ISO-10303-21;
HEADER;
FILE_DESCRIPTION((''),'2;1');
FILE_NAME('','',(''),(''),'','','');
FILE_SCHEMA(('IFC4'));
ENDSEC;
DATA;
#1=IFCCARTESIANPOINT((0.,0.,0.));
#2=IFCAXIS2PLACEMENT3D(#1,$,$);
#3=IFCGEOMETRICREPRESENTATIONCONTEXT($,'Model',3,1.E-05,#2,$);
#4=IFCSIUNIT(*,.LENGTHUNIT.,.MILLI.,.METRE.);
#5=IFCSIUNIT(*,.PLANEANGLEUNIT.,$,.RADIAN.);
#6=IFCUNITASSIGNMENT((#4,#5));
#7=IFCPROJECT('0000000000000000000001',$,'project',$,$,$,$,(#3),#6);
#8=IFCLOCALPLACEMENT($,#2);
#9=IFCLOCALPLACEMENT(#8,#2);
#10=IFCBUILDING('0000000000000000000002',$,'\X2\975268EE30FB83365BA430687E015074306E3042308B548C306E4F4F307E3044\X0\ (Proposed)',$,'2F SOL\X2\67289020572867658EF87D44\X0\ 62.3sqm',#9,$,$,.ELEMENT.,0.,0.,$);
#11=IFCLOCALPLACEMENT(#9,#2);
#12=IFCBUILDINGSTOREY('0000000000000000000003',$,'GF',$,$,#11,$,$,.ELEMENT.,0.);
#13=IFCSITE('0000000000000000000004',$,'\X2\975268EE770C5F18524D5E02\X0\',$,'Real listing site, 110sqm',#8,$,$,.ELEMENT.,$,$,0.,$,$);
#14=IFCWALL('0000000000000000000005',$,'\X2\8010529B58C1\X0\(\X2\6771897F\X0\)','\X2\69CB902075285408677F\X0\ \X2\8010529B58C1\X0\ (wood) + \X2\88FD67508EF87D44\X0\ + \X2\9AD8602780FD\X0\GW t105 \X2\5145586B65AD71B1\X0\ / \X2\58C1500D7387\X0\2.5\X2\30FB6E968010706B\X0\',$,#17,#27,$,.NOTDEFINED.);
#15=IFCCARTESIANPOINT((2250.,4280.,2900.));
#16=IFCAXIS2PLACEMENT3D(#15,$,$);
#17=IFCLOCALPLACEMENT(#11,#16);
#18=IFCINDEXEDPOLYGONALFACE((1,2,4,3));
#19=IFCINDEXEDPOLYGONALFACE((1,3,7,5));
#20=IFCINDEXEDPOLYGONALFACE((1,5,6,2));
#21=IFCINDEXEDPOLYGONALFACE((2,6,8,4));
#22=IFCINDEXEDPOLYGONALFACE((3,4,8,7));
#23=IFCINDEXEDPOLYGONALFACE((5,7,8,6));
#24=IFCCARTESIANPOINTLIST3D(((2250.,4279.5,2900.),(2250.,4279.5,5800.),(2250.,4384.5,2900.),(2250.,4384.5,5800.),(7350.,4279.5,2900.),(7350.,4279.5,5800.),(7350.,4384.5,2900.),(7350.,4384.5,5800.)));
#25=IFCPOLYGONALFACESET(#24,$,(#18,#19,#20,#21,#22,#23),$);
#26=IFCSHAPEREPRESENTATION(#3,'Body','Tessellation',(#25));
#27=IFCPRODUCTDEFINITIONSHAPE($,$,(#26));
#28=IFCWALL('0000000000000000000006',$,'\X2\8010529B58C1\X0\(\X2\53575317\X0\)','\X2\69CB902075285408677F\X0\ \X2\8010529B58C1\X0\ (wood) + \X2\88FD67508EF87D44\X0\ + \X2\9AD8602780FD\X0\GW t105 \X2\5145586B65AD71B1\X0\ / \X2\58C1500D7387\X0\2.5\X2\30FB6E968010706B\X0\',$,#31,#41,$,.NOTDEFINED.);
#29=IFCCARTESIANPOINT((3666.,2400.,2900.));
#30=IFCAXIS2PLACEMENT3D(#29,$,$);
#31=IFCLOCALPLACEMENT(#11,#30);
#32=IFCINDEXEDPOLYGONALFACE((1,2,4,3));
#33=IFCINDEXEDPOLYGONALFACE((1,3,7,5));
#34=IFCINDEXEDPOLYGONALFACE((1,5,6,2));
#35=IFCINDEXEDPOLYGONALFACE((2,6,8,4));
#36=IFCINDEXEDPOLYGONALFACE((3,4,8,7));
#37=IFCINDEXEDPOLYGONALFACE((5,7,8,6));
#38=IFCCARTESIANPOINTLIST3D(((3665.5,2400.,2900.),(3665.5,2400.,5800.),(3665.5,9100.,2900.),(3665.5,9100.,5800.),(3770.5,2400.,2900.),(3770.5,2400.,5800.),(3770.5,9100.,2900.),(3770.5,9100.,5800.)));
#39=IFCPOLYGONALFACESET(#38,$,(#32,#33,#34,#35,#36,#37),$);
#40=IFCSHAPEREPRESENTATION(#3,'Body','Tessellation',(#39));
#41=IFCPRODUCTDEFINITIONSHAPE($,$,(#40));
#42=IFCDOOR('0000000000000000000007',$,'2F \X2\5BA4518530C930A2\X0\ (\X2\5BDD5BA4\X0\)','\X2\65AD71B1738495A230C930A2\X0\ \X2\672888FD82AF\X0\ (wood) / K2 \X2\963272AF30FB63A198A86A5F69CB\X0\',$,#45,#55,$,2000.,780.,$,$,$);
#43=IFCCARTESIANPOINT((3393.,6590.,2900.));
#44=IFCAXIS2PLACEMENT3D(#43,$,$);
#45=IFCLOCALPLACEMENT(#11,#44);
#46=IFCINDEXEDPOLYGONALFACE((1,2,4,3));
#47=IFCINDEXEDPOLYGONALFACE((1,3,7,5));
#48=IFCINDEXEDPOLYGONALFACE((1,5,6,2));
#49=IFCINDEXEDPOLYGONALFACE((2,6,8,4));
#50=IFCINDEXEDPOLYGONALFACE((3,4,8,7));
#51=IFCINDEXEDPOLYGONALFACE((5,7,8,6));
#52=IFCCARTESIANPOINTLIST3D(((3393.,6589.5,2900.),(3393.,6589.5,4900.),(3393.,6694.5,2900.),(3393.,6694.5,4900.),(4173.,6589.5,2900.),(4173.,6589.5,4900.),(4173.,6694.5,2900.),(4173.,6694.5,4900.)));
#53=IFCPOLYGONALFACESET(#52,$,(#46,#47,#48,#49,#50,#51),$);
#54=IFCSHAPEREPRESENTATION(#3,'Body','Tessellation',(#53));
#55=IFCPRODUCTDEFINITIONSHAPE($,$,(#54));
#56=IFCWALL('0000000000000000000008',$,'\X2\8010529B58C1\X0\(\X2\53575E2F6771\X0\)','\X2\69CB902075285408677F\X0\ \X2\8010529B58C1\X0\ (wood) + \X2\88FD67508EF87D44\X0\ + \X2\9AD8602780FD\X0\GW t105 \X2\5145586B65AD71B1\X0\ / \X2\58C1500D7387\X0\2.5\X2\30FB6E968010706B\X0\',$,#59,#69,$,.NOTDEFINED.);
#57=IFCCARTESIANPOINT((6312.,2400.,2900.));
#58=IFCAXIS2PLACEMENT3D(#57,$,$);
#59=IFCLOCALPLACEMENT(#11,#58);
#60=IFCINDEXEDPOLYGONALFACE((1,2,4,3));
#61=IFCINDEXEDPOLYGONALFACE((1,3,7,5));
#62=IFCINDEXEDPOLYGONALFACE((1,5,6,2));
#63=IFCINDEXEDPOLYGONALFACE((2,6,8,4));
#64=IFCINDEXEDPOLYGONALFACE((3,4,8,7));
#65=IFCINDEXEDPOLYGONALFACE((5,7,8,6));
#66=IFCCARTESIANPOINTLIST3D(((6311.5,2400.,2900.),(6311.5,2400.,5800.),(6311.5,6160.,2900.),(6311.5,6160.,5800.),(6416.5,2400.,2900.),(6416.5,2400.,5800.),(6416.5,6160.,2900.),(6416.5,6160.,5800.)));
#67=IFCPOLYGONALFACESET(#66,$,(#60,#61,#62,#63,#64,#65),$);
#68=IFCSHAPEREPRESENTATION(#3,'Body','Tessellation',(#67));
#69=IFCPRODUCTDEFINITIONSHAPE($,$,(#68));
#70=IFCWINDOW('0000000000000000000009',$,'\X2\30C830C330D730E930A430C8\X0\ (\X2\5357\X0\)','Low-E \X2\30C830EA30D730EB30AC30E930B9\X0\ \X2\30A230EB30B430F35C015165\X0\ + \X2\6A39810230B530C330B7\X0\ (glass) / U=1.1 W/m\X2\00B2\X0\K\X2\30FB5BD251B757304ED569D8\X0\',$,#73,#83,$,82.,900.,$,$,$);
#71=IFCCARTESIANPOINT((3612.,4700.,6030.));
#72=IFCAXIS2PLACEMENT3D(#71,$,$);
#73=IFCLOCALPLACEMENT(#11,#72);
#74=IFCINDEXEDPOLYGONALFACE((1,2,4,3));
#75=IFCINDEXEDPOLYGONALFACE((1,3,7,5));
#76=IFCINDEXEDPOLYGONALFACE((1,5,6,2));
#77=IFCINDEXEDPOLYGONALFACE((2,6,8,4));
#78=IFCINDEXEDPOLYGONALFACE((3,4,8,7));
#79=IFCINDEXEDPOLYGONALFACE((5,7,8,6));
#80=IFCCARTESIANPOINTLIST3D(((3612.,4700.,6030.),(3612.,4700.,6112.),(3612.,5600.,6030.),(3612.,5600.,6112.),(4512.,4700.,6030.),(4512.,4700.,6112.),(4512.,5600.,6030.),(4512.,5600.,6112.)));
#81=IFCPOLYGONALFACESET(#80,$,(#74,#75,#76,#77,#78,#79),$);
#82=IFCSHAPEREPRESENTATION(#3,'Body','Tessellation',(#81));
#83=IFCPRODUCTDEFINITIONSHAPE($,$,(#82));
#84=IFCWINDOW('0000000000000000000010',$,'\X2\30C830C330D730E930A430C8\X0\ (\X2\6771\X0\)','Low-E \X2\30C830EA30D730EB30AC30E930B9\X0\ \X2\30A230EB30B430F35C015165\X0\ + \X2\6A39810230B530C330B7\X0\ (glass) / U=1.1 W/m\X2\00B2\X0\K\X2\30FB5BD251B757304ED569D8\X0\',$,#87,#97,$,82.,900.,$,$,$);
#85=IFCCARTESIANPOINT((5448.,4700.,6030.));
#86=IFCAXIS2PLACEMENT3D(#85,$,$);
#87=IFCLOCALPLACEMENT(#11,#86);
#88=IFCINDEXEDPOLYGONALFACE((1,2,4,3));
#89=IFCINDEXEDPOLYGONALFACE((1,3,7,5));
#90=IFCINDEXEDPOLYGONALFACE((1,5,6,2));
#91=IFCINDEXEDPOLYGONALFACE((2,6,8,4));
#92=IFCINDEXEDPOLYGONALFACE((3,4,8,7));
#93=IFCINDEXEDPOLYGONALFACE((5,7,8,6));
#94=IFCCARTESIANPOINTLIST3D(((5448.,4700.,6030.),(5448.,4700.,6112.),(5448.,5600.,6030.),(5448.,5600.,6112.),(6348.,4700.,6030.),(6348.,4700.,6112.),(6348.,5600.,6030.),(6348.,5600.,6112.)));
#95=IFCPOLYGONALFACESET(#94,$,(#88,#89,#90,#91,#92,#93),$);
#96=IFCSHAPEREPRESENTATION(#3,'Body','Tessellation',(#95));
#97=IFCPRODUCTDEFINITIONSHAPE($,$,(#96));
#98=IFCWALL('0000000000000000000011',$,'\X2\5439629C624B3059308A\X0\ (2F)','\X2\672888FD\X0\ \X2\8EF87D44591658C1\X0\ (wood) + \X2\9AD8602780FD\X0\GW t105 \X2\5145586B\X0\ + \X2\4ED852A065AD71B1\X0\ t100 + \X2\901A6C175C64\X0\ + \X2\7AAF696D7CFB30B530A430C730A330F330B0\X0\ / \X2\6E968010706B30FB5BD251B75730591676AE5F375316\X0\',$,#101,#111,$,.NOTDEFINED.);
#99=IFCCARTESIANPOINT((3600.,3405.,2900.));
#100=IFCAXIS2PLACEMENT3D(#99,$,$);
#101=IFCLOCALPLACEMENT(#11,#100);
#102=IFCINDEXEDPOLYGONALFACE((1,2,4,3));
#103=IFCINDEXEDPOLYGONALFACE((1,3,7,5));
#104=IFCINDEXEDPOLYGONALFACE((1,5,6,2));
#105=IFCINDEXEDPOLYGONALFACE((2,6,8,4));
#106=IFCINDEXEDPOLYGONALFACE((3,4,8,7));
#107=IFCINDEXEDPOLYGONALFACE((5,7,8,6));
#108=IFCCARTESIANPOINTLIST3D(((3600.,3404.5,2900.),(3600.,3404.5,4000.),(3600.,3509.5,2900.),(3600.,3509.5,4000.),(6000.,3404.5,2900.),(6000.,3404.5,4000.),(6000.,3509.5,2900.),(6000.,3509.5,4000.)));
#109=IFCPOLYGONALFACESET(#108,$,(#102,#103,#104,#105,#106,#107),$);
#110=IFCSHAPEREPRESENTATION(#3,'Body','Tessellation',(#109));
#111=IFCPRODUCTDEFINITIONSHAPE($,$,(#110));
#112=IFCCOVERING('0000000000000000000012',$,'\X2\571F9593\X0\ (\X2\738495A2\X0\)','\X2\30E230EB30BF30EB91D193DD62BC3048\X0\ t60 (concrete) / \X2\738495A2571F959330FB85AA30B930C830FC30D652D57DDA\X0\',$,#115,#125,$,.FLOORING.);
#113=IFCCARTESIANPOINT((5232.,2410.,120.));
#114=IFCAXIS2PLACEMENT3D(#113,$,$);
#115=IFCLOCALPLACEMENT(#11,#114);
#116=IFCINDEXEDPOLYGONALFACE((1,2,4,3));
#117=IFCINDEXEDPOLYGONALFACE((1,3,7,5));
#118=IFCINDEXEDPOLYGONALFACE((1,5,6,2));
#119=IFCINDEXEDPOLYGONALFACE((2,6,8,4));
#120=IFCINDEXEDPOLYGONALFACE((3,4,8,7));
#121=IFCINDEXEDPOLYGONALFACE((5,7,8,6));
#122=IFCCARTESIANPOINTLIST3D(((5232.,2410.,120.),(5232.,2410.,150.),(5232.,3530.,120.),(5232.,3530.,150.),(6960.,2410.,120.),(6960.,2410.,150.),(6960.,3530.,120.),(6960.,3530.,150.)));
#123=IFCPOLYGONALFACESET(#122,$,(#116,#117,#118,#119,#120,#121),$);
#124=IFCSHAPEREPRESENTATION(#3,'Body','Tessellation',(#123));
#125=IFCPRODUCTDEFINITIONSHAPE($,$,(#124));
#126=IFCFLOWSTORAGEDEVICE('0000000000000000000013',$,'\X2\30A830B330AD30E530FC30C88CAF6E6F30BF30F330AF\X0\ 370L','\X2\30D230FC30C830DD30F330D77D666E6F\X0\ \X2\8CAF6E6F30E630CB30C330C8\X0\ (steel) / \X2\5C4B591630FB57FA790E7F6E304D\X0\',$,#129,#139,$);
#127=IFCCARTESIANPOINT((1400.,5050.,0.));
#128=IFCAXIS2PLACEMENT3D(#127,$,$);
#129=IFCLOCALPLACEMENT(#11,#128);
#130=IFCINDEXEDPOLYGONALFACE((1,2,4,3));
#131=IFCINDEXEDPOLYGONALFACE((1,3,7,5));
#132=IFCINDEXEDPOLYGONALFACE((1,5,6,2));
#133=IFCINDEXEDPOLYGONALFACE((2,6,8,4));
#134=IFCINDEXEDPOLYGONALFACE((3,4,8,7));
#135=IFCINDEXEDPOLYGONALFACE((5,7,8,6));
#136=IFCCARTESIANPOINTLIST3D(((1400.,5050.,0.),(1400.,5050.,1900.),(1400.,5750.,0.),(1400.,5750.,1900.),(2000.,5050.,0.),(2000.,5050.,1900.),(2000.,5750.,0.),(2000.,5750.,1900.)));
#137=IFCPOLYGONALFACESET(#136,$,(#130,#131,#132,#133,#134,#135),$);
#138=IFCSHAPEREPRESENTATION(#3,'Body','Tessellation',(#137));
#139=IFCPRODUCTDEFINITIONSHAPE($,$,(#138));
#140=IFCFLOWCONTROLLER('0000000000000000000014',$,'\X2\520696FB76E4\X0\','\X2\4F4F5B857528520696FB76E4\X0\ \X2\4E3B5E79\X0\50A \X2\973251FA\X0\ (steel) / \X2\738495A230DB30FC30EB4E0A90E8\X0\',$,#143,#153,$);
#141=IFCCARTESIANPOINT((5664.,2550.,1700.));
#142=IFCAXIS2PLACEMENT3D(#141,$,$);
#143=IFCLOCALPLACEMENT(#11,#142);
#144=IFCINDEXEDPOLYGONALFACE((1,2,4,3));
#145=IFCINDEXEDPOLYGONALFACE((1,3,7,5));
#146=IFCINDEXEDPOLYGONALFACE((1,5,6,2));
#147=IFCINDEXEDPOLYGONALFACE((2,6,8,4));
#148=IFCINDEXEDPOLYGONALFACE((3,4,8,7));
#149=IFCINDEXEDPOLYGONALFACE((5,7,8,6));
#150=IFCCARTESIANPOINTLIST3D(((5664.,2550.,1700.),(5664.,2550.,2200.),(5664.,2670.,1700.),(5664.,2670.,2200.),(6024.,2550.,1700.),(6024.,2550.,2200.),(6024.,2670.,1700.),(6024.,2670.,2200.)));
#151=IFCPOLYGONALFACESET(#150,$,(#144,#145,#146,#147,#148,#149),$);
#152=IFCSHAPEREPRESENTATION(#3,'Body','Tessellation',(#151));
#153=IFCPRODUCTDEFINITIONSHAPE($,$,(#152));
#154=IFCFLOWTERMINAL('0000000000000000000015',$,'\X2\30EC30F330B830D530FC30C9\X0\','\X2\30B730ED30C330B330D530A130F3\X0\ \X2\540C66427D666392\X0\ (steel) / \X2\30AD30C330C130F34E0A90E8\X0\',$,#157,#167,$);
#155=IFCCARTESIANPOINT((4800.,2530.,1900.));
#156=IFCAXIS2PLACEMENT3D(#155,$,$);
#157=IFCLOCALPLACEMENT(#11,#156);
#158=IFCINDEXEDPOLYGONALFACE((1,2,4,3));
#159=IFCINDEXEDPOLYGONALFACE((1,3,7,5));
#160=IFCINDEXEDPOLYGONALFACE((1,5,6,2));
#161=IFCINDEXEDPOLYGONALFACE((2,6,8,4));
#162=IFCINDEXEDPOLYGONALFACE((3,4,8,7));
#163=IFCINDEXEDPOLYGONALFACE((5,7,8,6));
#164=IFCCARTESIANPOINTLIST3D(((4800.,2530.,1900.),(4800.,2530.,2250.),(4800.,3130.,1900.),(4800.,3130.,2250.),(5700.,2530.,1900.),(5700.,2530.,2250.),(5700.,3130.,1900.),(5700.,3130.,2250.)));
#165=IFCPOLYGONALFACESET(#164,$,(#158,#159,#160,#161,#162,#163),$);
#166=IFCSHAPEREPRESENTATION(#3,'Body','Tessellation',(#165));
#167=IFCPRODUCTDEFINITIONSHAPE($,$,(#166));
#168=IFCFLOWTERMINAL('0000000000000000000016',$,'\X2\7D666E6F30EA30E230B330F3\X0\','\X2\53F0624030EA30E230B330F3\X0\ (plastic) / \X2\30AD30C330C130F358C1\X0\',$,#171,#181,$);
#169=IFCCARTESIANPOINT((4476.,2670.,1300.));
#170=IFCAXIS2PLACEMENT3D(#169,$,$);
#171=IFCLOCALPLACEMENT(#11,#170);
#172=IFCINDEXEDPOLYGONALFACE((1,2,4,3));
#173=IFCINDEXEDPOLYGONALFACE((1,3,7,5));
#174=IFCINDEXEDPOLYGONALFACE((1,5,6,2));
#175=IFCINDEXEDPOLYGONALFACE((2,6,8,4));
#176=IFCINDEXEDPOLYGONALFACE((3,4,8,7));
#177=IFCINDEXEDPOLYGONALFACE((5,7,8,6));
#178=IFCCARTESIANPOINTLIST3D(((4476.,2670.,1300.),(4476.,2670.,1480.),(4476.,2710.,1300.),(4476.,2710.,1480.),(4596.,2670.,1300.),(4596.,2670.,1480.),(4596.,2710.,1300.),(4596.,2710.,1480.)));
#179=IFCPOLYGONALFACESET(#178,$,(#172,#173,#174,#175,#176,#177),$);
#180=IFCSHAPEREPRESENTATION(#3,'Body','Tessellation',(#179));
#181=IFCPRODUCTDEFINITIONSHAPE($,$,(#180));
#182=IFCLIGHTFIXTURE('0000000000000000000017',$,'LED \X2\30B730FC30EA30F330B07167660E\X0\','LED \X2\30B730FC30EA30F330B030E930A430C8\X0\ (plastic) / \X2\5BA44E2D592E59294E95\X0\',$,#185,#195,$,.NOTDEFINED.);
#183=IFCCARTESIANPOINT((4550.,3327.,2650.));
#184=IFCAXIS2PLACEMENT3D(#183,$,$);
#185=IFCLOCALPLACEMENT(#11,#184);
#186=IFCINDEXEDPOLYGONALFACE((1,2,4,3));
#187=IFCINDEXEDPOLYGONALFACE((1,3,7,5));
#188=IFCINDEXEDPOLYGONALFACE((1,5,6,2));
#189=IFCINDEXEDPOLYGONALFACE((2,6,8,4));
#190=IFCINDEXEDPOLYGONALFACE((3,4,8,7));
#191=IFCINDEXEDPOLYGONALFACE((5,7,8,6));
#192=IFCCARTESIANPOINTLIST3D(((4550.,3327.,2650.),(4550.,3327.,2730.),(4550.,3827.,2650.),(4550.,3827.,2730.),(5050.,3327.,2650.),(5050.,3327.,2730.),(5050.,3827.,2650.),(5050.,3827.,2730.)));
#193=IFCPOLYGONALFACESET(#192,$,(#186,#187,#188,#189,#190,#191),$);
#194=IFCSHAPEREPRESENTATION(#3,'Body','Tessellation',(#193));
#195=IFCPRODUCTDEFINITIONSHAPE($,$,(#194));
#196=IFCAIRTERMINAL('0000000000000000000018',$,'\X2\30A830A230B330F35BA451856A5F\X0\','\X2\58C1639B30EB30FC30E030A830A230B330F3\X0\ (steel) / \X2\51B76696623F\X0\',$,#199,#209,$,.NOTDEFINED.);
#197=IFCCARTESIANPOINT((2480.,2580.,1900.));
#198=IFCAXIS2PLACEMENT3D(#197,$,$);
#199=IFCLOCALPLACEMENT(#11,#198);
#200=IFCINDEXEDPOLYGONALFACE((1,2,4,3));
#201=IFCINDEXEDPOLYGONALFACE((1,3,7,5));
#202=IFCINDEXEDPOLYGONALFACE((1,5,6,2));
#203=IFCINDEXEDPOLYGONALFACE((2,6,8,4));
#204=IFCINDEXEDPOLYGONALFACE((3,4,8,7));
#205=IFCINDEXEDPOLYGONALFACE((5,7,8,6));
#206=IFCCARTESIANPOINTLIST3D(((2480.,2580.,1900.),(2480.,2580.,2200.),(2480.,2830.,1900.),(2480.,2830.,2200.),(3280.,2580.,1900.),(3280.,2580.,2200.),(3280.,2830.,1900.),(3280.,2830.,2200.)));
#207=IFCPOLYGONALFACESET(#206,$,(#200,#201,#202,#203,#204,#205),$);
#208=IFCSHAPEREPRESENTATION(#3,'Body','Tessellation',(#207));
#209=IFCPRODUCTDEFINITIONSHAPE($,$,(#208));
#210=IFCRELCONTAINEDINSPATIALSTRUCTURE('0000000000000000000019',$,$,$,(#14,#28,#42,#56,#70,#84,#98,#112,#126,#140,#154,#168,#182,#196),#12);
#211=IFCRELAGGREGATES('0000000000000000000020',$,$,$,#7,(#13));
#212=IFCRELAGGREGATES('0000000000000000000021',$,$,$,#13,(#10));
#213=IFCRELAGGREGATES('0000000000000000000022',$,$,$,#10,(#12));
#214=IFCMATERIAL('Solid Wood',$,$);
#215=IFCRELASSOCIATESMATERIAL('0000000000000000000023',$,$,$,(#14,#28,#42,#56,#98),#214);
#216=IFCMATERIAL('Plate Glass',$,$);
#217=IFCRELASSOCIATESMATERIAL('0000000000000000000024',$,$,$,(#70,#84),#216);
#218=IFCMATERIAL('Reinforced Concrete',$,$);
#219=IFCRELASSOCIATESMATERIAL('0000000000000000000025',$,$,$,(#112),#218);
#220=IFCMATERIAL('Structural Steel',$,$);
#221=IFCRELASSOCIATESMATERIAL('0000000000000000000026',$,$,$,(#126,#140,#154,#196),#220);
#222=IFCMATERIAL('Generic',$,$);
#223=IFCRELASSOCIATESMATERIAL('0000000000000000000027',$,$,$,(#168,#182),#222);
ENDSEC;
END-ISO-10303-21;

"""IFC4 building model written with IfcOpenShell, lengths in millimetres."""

from ifc_helpers import new_model, si_unit, frame, frame_2d, origin, place, context, project, spatial, rectangle, extrude, material, element, fill, save


model = new_model("IFC4")

# Units and contexts
model_context = context("Model", 3, precision=1e-05, world=origin())
ifc_project = project(units=[si_unit("LENGTHUNIT", "METRE", prefix="MILLI"), si_unit("PLANEANGLEUNIT", "RADIAN")], contexts=[model_context])

# Site, building, storey
site_placement = place(None, origin())
site = spatial("IfcSite", under=ifc_project, at=site_placement, Name="青森県弘前市", ObjectType="Real listing site, 110sqm", CompositionType="ELEMENT", RefElevation=0.0)
building_placement = place(site_placement, origin())
building = spatial("IfcBuilding", under=site, at=building_placement, Name="青森・茶室と縁側のある和の住まい (Proposed)", ObjectType="2F SOL木造在来軸組 62.3sqm", CompositionType="ELEMENT", ElevationOfRefHeight=0.0, ElevationOfTerrain=0.0)
storey_placement = place(building_placement, origin())
storey = spatial("IfcBuildingStorey", under=building, at=storey_placement, Name="GF", CompositionType="ELEMENT", Elevation=0.0)

# Shared definitions
ifc_material_1 = material(Name="Solid Wood")

# Wall
wall_1_placement = place(storey_placement, frame((2250.0, 4280.0, 2900.0)))
element("IfcWall", 1, at=wall_1_placement, inside=storey, material=ifc_material_1, Name="耐力壁(東西)", Description="構造用合板 耐力壁 (wood) + 製材軸組 + 高性能GW t105 充填断熱 / 壁倍率2.5・準耐火", PredefinedType="NOTDEFINED", context=model_context, shape_type="SweptSolid", body=[
    extrude(rectangle(XDim=5100.0, YDim=105.0, at=frame_2d((2550.0, 52.0))), frame((2250.0, 4280.0, 2900.0)), (0.0, 0.0, 1.0), 2900.0),
])

# Wall, opening, door
wall_2_placement = place(storey_placement, frame((3666.0, 2400.0, 2900.0)))
wall_2 = element("IfcWall", 2, at=wall_2_placement, inside=storey, material=ifc_material_1, Name="耐力壁(南北)", Description="構造用合板 耐力壁 (wood) + 製材軸組 + 高性能GW t105 充填断熱 / 壁倍率2.5・準耐火", PredefinedType="NOTDEFINED", context=model_context, shape_type="SweptSolid", body=[
    extrude(rectangle(XDim=105.0, YDim=6700.0, at=frame_2d((52.0, 3350.0))), frame((3666.0, 2400.0, 2900.0)), (0.0, 0.0, 1.0), 2900.0),
])
opening_placement = place(storey_placement, frame((3393.0, 6590.0, 2900.0)))
opening = element("IfcOpeningElement", 3, at=opening_placement, cuts=wall_2, PredefinedType="NOTDEFINED", context=model_context, shape_type="SweptSolid", body=[
    extrude(rectangle(XDim=780.0, YDim=105.0, at=frame_2d((390.0, 52.0))), frame((3393.0, 6590.0, 2900.0)), (0.0, 0.0, 1.0), 2000.0),
])
door_placement = place(storey_placement, frame((3393.0, 6590.0, 2900.0)))
door = element("IfcDoor", 4, at=door_placement, inside=storey, material=ifc_material_1, Name="2F 室内ドア (寝室)", Description="断熱玄関ドア 木製芯 (wood) / K2 防犯・採風機構", OverallHeight=2000.0, OverallWidth=780.0, context=model_context, shape_type="SweptSolid", body=[
    extrude(rectangle(XDim=780.0, YDim=105.0, at=frame_2d((390.0, 52.0))), frame((3393.0, 6590.0, 2900.0)), (0.0, 0.0, 1.0), 2000.0),
])
fill(opening, door)

# Wall
wall_3_placement = place(storey_placement, frame((6312.0, 2400.0, 2900.0)))
element("IfcWall", 5, at=wall_3_placement, inside=storey, material=ifc_material_1, Name="耐力壁(南帯東)", Description="構造用合板 耐力壁 (wood) + 製材軸組 + 高性能GW t105 充填断熱 / 壁倍率2.5・準耐火", PredefinedType="NOTDEFINED", context=model_context, shape_type="SweptSolid", body=[
    extrude(rectangle(XDim=105.0, YDim=3760.0, at=frame_2d((52.0, 1880.0))), frame((6312.0, 2400.0, 2900.0)), (0.0, 0.0, 1.0), 2900.0),
])

# Windows
ifc_material_2 = material(Name="Plate Glass")
window_1_placement = place(storey_placement, frame((3612.0, 4700.0, 6030.0)))
element("IfcWindow", 6, at=window_1_placement, inside=storey, material=ifc_material_2, Name="トップライト (南)", Description="Low-E トリプルガラス アルゴン封入 + 樹脂サッシ (glass) / U=1.1 W/m²K・寒冷地仕様", OverallHeight=82.0, OverallWidth=900.0, context=model_context, shape_type="SweptSolid", body=[
    extrude(rectangle(XDim=900.0, YDim=900.0, at=frame_2d((450.0, 450.0))), frame((3612.0, 4700.0, 6030.0)), (0.0, 0.0, 1.0), 82.0),
])
window_2_placement = place(storey_placement, frame((5448.0, 4700.0, 6030.0)))
element("IfcWindow", 7, at=window_2_placement, inside=storey, material=ifc_material_2, Name="トップライト (東)", Description="Low-E トリプルガラス アルゴン封入 + 樹脂サッシ (glass) / U=1.1 W/m²K・寒冷地仕様", OverallHeight=82.0, OverallWidth=900.0, context=model_context, shape_type="SweptSolid", body=[
    extrude(rectangle(XDim=900.0, YDim=900.0, at=frame_2d((450.0, 450.0))), frame((5448.0, 4700.0, 6030.0)), (0.0, 0.0, 1.0), 82.0),
])

# Wall
wall_4_placement = place(storey_placement, frame((3600.0, 3405.0, 2900.0)))
element("IfcWall", 8, at=wall_4_placement, inside=storey, material=ifc_material_1, Name="吹抜手すり (2F)", Description="木製 軸組外壁 (wood) + 高性能GW t105 充填 + 付加断熱 t100 + 通気層 + 窯業系サイディング / 準耐火・寒冷地外皮強化", PredefinedType="NOTDEFINED", context=model_context, shape_type="SweptSolid", body=[
    extrude(rectangle(XDim=2400.0, YDim=105.0, at=frame_2d((1200.0, 52.0))), frame((3600.0, 3405.0, 2900.0)), (0.0, 0.0, 1.0), 1100.0),
])

# Covering
ifc_material_3 = material(Name="Reinforced Concrete")
covering_placement = place(storey_placement, frame((5232.0, 2410.0, 120.0)))
element("IfcCovering", 9, at=covering_placement, inside=storey, material=ifc_material_3, Name="土間 (玄関)", Description="モルタル金鏝押え t60 (concrete) / 玄関土間・薪ストーブ動線", PredefinedType="FLOORING", context=model_context, shape_type="SweptSolid", body=[
    extrude(rectangle(XDim=1728.0, YDim=1120.0, at=frame_2d((864.0, 560.0))), frame((5232.0, 2410.0, 120.0)), (0.0, 0.0, 1.0), 30.0),
])

# Flow storage device
ifc_material_4 = material(Name="Structural Steel")
flow_storage_device_placement = place(storey_placement, frame((1400.0, 5050.0, 0.0)))
element("IfcFlowStorageDevice", 10, at=flow_storage_device_placement, inside=storey, material=ifc_material_4, Name="エコキュート貯湯タンク 370L", Description="ヒートポンプ給湯 貯湯ユニット (steel) / 屋外・基礎置き", context=model_context, shape_type="SweptSolid", body=[
    extrude(rectangle(XDim=600.0, YDim=700.0, at=frame_2d((300.0, 350.0))), frame((1400.0, 5050.0, 0.0)), (0.0, 0.0, 1.0), 1900.0),
])

# Flow controller
flow_controller_placement = place(storey_placement, frame((5664.0, 2550.0, 1700.0)))
element("IfcFlowController", 11, at=flow_controller_placement, inside=storey, material=ifc_material_4, Name="分電盤", Description="住宅用分電盤 主幹50A 露出 (steel) / 玄関ホール上部", context=model_context, shape_type="SweptSolid", body=[
    extrude(rectangle(XDim=360.0, YDim=120.0, at=frame_2d((180.0, 60.0))), frame((5664.0, 2550.0, 1700.0)), (0.0, 0.0, 1.0), 500.0),
])

# Flow terminals
flow_terminal_1_placement = place(storey_placement, frame((4800.0, 2530.0, 1900.0)))
element("IfcFlowTerminal", 12, at=flow_terminal_1_placement, inside=storey, material=ifc_material_4, Name="レンジフード", Description="シロッコファン 同時給排 (steel) / キッチン上部", context=model_context, shape_type="SweptSolid", body=[
    extrude(rectangle(XDim=900.0, YDim=600.0, at=frame_2d((450.0, 300.0))), frame((4800.0, 2530.0, 1900.0)), (0.0, 0.0, 1.0), 350.0),
])
ifc_material_5 = material(Name="Generic")
flow_terminal_2_placement = place(storey_placement, frame((4476.0, 2670.0, 1300.0)))
element("IfcFlowTerminal", 13, at=flow_terminal_2_placement, inside=storey, material=ifc_material_5, Name="給湯リモコン", Description="台所リモコン (plastic) / キッチン壁", context=model_context, shape_type="SweptSolid", body=[
    extrude(rectangle(XDim=120.0, YDim=40.0, at=frame_2d((60.0, 20.0))), frame((4476.0, 2670.0, 1300.0)), (0.0, 0.0, 1.0), 180.0),
])

# Light fixture
light_fixture_1_placement = place(storey_placement, frame((4550.0, 3327.0, 2650.0)))
element("IfcLightFixture", 14, at=light_fixture_1_placement, inside=storey, material=ifc_material_5, Name="LED シーリング照明", Description="LED シーリングライト (plastic) / 室中央天井", PredefinedType="NOTDEFINED", context=model_context, shape_type="SweptSolid", body=[
    extrude(rectangle(XDim=500.0, YDim=500.0, at=frame_2d((250.0, 250.0))), frame((4550.0, 3327.0, 2650.0)), (0.0, 0.0, 1.0), 80.0),
])

# Air terminal
air_terminal_1_placement = place(storey_placement, frame((2480.0, 2580.0, 1900.0)))
element("IfcAirTerminal", 15, at=air_terminal_1_placement, inside=storey, material=ifc_material_4, Name="エアコン室内機", Description="壁掛ルームエアコン (steel) / 冷暖房", PredefinedType="NOTDEFINED", context=model_context, shape_type="SweptSolid", body=[
    extrude(rectangle(XDim=800.0, YDim=250.0, at=frame_2d((400.0, 125.0))), frame((2480.0, 2580.0, 1900.0)), (0.0, 0.0, 1.0), 300.0),
])

save(model, "model.ifc")
